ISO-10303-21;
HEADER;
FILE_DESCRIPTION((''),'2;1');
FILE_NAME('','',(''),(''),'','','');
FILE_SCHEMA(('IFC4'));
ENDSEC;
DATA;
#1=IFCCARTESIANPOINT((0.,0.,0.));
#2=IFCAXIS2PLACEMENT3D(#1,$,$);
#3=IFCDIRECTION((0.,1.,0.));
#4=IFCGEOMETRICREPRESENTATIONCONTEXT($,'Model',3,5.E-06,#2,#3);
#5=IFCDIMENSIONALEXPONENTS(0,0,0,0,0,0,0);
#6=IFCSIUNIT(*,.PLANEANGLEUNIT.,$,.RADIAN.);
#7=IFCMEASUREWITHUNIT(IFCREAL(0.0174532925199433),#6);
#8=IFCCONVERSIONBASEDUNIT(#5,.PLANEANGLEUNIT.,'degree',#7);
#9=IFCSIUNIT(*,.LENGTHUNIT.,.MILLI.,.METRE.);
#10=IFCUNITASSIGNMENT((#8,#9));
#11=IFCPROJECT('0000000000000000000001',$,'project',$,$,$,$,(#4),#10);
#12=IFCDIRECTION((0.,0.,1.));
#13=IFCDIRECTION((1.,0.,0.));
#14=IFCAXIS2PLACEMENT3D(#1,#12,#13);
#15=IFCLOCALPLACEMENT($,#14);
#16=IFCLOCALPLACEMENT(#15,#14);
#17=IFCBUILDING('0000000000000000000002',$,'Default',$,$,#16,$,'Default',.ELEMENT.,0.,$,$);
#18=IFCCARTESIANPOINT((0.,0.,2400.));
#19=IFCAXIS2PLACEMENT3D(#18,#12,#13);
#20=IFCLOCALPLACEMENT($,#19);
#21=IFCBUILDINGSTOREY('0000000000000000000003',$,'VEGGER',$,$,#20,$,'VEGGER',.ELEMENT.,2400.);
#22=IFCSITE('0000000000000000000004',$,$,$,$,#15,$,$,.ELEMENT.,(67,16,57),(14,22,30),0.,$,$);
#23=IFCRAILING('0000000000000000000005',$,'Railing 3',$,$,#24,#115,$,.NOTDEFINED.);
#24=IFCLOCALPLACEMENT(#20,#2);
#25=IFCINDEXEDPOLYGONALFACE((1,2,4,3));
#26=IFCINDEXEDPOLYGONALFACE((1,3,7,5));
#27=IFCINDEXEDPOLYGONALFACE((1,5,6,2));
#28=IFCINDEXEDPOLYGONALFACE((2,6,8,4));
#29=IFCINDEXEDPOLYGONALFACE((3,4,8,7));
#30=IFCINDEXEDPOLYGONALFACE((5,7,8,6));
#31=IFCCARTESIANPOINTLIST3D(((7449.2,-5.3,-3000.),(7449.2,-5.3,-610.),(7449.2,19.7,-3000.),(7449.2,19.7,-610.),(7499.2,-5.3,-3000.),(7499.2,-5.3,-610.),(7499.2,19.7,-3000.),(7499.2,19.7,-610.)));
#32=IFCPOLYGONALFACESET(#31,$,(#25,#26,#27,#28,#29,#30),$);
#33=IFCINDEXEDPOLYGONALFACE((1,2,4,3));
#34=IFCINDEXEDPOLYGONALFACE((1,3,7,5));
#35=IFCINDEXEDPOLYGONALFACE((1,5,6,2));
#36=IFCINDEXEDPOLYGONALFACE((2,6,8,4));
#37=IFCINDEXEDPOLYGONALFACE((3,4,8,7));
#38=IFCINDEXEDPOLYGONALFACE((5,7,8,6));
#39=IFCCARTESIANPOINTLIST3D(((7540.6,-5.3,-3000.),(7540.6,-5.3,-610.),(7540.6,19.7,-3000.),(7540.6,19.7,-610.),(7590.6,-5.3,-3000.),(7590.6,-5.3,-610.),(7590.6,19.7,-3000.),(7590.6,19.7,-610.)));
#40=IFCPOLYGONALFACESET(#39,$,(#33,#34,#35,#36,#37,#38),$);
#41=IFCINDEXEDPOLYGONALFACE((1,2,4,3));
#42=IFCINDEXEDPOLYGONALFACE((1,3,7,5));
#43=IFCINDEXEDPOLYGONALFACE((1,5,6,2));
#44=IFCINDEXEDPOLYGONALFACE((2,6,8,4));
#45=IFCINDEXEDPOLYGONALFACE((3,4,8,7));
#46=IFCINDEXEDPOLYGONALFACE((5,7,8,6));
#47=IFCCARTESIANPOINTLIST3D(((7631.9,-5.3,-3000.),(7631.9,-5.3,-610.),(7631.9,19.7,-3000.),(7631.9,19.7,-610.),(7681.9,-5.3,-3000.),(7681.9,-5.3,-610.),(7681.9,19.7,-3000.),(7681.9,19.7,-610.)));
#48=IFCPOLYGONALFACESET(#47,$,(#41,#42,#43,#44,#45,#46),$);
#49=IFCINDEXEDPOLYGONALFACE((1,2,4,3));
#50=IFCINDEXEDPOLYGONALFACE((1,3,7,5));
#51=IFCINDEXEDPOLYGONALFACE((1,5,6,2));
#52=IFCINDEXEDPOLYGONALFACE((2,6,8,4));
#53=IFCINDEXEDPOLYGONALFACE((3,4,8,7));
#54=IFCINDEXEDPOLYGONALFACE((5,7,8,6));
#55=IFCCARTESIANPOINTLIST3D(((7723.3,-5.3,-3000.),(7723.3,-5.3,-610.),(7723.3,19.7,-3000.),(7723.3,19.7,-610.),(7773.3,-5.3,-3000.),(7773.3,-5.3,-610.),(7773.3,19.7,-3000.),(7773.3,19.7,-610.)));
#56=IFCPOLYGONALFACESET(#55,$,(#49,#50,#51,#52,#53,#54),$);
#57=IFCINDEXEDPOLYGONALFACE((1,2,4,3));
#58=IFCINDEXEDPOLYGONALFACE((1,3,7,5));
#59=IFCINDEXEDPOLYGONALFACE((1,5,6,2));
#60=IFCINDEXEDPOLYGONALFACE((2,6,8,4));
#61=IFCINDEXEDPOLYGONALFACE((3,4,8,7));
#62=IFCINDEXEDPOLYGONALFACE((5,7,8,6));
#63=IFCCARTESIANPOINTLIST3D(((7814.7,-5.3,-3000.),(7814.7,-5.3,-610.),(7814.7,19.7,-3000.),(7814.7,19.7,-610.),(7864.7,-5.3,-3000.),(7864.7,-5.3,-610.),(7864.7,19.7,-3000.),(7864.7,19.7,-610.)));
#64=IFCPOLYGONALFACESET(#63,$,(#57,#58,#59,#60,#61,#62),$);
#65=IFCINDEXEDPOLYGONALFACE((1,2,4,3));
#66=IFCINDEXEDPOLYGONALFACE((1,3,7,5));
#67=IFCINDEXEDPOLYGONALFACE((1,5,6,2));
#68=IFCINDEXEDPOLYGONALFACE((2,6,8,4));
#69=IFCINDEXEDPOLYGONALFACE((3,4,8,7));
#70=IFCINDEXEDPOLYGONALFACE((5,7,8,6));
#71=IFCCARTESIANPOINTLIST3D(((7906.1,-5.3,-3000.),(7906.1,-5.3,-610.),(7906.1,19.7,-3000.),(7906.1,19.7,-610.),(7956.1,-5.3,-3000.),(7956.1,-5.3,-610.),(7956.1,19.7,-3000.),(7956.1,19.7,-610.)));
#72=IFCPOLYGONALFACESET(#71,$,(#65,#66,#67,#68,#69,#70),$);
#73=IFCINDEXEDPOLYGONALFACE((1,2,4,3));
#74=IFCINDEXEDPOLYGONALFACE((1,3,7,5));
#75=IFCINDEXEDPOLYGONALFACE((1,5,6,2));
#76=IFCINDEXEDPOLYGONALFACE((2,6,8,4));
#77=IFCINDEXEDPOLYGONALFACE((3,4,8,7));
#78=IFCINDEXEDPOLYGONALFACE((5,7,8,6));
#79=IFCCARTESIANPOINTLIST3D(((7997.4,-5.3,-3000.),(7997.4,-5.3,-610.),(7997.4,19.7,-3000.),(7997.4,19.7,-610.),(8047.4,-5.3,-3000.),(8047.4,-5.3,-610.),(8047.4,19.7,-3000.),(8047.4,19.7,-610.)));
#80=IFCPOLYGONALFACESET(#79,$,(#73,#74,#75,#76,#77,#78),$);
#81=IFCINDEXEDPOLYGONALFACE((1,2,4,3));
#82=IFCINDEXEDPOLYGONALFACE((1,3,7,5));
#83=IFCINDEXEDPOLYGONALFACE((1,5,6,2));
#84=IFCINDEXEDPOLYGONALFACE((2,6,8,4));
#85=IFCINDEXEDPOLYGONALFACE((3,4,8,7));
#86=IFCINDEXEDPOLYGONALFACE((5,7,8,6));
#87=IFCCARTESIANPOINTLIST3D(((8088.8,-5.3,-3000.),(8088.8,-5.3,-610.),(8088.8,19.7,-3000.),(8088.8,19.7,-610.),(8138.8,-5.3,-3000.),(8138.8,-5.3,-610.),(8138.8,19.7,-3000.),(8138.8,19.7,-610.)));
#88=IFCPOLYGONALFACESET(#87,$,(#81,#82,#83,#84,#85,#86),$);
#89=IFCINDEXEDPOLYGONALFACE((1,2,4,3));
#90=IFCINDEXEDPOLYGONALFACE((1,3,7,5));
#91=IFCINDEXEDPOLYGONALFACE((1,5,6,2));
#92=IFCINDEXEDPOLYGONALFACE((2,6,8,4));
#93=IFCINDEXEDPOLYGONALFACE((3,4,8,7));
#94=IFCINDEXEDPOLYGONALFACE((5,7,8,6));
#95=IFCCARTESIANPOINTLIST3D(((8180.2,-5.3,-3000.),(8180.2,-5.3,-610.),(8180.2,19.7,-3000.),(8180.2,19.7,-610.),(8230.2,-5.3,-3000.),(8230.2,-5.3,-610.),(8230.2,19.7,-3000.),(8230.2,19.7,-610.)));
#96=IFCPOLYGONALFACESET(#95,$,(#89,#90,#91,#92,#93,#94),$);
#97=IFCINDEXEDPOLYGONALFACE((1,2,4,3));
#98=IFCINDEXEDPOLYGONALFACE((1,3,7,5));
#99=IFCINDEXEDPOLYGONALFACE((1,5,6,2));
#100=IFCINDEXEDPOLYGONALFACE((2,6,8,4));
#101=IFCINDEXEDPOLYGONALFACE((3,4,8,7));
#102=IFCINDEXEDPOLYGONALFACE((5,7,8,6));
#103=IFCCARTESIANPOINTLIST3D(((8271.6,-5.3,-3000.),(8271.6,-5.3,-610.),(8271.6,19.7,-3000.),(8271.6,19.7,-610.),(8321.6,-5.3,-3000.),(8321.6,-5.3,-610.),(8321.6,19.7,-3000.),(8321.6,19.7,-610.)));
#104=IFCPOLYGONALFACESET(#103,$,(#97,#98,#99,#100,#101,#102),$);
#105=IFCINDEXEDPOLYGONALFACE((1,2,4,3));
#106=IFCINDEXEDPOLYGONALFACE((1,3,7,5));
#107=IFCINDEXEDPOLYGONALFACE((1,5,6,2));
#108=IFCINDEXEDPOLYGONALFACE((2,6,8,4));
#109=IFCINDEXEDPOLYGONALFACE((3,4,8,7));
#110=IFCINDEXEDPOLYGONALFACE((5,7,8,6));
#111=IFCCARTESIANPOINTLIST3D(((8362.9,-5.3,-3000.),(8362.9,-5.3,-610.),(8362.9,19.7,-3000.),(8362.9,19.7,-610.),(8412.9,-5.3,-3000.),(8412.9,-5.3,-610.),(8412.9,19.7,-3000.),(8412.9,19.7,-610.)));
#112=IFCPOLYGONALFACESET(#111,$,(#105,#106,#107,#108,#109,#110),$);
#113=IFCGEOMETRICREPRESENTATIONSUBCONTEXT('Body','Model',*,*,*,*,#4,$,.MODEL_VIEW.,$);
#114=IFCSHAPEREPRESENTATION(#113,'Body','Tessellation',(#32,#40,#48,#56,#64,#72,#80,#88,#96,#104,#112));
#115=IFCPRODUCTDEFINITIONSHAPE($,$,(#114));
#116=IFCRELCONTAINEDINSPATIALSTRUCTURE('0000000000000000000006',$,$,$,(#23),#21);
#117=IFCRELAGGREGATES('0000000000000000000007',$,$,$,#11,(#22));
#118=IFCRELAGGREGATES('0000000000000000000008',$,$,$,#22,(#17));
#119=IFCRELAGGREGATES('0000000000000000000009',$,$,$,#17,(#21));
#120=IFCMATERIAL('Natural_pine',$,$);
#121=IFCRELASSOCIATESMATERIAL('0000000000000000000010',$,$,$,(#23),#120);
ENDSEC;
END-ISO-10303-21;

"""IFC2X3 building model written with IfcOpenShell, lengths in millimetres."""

from ifc_helpers import new_model, entity, si_unit, converted_unit, direction, frame, origin, origin_with_axes, place, context, subcontext, project, spatial, polyline, outline, extrude, material, element, save


model = new_model("IFC2X3")

# Units and contexts
model_context = context("Model", 3, precision=5e-06, world=origin(), true_north=direction((0.0, 1.0, 0.0)))
body_context = subcontext(model_context, "Body", "Model", "MODEL_VIEW")
ifc_project = project(units=[converted_unit("PLANEANGLEUNIT", "degree", entity("IfcReal", 0.0174532925199433), si_unit("PLANEANGLEUNIT", "RADIAN"), dimensions=[0, 0, 0, 0, 0, 0, 0]), si_unit("LENGTHUNIT", "METRE", prefix="MILLI")], contexts=[model_context])

# Site, building, storey
site_placement = place(None, origin_with_axes())
site = spatial("IfcSite", under=ifc_project, at=site_placement, CompositionType="ELEMENT", RefLatitude=(67, 16, 57), RefLongitude=(14, 22, 30), RefElevation=0.0)
building_placement = place(site_placement, origin_with_axes())
building = spatial("IfcBuilding", under=site, at=building_placement, Name="Default", LongName="Default", CompositionType="ELEMENT", ElevationOfRefHeight=0.0)
storey_placement = place(None, frame((0.0, 0.0, 2400.0), z_axis=(0.0, 0.0, 1.0), x_axis=(1.0, 0.0, 0.0)))
storey = spatial("IfcBuildingStorey", under=building, at=storey_placement, Name="VEGGER", LongName="VEGGER", CompositionType="ELEMENT", Elevation=2400.0)

# Railing
ifc_material_1 = material(Name="Natural_pine")
railing_1_placement = place(storey_placement, frame((7449.2, -5.3, -3000.0), z_axis=(0.0, 0.0, 1.0), x_axis=(1.0, 0.0, 0.0)))
element("IfcRailing", 1, at=railing_1_placement, inside=storey, material=ifc_material_1, Name="Railing 3", PredefinedType="NOTDEFINED", context=body_context, shape_type="SweptSolid", body=[
    extrude(outline(polyline([(0.0, -12.5), (50.0, -12.5), (50.0, 12.5), (0.0, 12.5), (0.0, -12.5)])), frame((0.0, 12.5, 0.0), z_axis=(0.0, 0.0, 1.0), x_axis=(1.0, 0.0, 0.0)), (0.0, 0.0, 1.0), 2390.0),
    extrude(outline(polyline([(0.0, -12.5), (50.0, -12.5), (50.0, 12.5), (0.0, 12.5), (0.0, -12.5)])), frame((91.4, 12.5, 0.0), z_axis=(0.0, 0.0, 1.0), x_axis=(1.0, 0.0, 0.0)), (0.0, 0.0, 1.0), 2390.0),
    extrude(outline(polyline([(0.0, -12.5), (50.0, -12.5), (50.0, 12.5), (0.0, 12.5), (0.0, -12.5)])), frame((182.7, 12.5, 0.0), z_axis=(0.0, 0.0, 1.0), x_axis=(1.0, 0.0, 0.0)), (0.0, 0.0, 1.0), 2390.0),
    extrude(outline(polyline([(0.0, -12.5), (50.0, -12.5), (50.0, 12.5), (0.0, 12.5), (0.0, -12.5)])), frame((274.1, 12.5, 0.0), z_axis=(0.0, 0.0, 1.0), x_axis=(1.0, 0.0, 0.0)), (0.0, 0.0, 1.0), 2390.0),
    extrude(outline(polyline([(0.0, -12.5), (50.0, -12.5), (50.0, 12.5), (0.0, 12.5), (0.0, -12.5)])), frame((365.5, 12.5, 0.0), z_axis=(0.0, 0.0, 1.0), x_axis=(1.0, 0.0, 0.0)), (0.0, 0.0, 1.0), 2390.0),
    extrude(outline(polyline([(0.0, -12.5), (50.0, -12.5), (50.0, 12.5), (0.0, 12.5), (0.0, -12.5)])), frame((456.9, 12.5, 0.0), z_axis=(0.0, 0.0, 1.0), x_axis=(1.0, 0.0, 0.0)), (0.0, 0.0, 1.0), 2390.0),
    extrude(outline(polyline([(0.0, -12.5), (50.0, -12.5), (50.0, 12.5), (0.0, 12.5), (0.0, -12.5)])), frame((548.2, 12.5, 0.0), z_axis=(0.0, 0.0, 1.0), x_axis=(1.0, 0.0, 0.0)), (0.0, 0.0, 1.0), 2390.0),
    extrude(outline(polyline([(0.0, -12.5), (50.0, -12.5), (50.0, 12.5), (0.0, 12.5), (0.0, -12.5)])), frame((639.6, 12.5, 0.0), z_axis=(0.0, 0.0, 1.0), x_axis=(1.0, 0.0, 0.0)), (0.0, 0.0, 1.0), 2390.0),
    extrude(outline(polyline([(0.0, -12.5), (50.0, -12.5), (50.0, 12.5), (0.0, 12.5), (0.0, -12.5)])), frame((731.0, 12.5, 0.0), z_axis=(0.0, 0.0, 1.0), x_axis=(1.0, 0.0, 0.0)), (0.0, 0.0, 1.0), 2390.0),
    extrude(outline(polyline([(0.0, -12.5), (50.0, -12.5), (50.0, 12.5), (0.0, 12.5), (0.0, -12.5)])), frame((822.4, 12.5, 0.0), z_axis=(0.0, 0.0, 1.0), x_axis=(1.0, 0.0, 0.0)), (0.0, 0.0, 1.0), 2390.0),
    extrude(outline(polyline([(0.0, -12.5), (50.0, -12.5), (50.0, 12.5), (0.0, 12.5), (0.0, -12.5)])), frame((913.7, 12.5, 0.0), z_axis=(0.0, 0.0, 1.0), x_axis=(1.0, 0.0, 0.0)), (0.0, 0.0, 1.0), 2390.0),
])

save(model, "model.ifc")
